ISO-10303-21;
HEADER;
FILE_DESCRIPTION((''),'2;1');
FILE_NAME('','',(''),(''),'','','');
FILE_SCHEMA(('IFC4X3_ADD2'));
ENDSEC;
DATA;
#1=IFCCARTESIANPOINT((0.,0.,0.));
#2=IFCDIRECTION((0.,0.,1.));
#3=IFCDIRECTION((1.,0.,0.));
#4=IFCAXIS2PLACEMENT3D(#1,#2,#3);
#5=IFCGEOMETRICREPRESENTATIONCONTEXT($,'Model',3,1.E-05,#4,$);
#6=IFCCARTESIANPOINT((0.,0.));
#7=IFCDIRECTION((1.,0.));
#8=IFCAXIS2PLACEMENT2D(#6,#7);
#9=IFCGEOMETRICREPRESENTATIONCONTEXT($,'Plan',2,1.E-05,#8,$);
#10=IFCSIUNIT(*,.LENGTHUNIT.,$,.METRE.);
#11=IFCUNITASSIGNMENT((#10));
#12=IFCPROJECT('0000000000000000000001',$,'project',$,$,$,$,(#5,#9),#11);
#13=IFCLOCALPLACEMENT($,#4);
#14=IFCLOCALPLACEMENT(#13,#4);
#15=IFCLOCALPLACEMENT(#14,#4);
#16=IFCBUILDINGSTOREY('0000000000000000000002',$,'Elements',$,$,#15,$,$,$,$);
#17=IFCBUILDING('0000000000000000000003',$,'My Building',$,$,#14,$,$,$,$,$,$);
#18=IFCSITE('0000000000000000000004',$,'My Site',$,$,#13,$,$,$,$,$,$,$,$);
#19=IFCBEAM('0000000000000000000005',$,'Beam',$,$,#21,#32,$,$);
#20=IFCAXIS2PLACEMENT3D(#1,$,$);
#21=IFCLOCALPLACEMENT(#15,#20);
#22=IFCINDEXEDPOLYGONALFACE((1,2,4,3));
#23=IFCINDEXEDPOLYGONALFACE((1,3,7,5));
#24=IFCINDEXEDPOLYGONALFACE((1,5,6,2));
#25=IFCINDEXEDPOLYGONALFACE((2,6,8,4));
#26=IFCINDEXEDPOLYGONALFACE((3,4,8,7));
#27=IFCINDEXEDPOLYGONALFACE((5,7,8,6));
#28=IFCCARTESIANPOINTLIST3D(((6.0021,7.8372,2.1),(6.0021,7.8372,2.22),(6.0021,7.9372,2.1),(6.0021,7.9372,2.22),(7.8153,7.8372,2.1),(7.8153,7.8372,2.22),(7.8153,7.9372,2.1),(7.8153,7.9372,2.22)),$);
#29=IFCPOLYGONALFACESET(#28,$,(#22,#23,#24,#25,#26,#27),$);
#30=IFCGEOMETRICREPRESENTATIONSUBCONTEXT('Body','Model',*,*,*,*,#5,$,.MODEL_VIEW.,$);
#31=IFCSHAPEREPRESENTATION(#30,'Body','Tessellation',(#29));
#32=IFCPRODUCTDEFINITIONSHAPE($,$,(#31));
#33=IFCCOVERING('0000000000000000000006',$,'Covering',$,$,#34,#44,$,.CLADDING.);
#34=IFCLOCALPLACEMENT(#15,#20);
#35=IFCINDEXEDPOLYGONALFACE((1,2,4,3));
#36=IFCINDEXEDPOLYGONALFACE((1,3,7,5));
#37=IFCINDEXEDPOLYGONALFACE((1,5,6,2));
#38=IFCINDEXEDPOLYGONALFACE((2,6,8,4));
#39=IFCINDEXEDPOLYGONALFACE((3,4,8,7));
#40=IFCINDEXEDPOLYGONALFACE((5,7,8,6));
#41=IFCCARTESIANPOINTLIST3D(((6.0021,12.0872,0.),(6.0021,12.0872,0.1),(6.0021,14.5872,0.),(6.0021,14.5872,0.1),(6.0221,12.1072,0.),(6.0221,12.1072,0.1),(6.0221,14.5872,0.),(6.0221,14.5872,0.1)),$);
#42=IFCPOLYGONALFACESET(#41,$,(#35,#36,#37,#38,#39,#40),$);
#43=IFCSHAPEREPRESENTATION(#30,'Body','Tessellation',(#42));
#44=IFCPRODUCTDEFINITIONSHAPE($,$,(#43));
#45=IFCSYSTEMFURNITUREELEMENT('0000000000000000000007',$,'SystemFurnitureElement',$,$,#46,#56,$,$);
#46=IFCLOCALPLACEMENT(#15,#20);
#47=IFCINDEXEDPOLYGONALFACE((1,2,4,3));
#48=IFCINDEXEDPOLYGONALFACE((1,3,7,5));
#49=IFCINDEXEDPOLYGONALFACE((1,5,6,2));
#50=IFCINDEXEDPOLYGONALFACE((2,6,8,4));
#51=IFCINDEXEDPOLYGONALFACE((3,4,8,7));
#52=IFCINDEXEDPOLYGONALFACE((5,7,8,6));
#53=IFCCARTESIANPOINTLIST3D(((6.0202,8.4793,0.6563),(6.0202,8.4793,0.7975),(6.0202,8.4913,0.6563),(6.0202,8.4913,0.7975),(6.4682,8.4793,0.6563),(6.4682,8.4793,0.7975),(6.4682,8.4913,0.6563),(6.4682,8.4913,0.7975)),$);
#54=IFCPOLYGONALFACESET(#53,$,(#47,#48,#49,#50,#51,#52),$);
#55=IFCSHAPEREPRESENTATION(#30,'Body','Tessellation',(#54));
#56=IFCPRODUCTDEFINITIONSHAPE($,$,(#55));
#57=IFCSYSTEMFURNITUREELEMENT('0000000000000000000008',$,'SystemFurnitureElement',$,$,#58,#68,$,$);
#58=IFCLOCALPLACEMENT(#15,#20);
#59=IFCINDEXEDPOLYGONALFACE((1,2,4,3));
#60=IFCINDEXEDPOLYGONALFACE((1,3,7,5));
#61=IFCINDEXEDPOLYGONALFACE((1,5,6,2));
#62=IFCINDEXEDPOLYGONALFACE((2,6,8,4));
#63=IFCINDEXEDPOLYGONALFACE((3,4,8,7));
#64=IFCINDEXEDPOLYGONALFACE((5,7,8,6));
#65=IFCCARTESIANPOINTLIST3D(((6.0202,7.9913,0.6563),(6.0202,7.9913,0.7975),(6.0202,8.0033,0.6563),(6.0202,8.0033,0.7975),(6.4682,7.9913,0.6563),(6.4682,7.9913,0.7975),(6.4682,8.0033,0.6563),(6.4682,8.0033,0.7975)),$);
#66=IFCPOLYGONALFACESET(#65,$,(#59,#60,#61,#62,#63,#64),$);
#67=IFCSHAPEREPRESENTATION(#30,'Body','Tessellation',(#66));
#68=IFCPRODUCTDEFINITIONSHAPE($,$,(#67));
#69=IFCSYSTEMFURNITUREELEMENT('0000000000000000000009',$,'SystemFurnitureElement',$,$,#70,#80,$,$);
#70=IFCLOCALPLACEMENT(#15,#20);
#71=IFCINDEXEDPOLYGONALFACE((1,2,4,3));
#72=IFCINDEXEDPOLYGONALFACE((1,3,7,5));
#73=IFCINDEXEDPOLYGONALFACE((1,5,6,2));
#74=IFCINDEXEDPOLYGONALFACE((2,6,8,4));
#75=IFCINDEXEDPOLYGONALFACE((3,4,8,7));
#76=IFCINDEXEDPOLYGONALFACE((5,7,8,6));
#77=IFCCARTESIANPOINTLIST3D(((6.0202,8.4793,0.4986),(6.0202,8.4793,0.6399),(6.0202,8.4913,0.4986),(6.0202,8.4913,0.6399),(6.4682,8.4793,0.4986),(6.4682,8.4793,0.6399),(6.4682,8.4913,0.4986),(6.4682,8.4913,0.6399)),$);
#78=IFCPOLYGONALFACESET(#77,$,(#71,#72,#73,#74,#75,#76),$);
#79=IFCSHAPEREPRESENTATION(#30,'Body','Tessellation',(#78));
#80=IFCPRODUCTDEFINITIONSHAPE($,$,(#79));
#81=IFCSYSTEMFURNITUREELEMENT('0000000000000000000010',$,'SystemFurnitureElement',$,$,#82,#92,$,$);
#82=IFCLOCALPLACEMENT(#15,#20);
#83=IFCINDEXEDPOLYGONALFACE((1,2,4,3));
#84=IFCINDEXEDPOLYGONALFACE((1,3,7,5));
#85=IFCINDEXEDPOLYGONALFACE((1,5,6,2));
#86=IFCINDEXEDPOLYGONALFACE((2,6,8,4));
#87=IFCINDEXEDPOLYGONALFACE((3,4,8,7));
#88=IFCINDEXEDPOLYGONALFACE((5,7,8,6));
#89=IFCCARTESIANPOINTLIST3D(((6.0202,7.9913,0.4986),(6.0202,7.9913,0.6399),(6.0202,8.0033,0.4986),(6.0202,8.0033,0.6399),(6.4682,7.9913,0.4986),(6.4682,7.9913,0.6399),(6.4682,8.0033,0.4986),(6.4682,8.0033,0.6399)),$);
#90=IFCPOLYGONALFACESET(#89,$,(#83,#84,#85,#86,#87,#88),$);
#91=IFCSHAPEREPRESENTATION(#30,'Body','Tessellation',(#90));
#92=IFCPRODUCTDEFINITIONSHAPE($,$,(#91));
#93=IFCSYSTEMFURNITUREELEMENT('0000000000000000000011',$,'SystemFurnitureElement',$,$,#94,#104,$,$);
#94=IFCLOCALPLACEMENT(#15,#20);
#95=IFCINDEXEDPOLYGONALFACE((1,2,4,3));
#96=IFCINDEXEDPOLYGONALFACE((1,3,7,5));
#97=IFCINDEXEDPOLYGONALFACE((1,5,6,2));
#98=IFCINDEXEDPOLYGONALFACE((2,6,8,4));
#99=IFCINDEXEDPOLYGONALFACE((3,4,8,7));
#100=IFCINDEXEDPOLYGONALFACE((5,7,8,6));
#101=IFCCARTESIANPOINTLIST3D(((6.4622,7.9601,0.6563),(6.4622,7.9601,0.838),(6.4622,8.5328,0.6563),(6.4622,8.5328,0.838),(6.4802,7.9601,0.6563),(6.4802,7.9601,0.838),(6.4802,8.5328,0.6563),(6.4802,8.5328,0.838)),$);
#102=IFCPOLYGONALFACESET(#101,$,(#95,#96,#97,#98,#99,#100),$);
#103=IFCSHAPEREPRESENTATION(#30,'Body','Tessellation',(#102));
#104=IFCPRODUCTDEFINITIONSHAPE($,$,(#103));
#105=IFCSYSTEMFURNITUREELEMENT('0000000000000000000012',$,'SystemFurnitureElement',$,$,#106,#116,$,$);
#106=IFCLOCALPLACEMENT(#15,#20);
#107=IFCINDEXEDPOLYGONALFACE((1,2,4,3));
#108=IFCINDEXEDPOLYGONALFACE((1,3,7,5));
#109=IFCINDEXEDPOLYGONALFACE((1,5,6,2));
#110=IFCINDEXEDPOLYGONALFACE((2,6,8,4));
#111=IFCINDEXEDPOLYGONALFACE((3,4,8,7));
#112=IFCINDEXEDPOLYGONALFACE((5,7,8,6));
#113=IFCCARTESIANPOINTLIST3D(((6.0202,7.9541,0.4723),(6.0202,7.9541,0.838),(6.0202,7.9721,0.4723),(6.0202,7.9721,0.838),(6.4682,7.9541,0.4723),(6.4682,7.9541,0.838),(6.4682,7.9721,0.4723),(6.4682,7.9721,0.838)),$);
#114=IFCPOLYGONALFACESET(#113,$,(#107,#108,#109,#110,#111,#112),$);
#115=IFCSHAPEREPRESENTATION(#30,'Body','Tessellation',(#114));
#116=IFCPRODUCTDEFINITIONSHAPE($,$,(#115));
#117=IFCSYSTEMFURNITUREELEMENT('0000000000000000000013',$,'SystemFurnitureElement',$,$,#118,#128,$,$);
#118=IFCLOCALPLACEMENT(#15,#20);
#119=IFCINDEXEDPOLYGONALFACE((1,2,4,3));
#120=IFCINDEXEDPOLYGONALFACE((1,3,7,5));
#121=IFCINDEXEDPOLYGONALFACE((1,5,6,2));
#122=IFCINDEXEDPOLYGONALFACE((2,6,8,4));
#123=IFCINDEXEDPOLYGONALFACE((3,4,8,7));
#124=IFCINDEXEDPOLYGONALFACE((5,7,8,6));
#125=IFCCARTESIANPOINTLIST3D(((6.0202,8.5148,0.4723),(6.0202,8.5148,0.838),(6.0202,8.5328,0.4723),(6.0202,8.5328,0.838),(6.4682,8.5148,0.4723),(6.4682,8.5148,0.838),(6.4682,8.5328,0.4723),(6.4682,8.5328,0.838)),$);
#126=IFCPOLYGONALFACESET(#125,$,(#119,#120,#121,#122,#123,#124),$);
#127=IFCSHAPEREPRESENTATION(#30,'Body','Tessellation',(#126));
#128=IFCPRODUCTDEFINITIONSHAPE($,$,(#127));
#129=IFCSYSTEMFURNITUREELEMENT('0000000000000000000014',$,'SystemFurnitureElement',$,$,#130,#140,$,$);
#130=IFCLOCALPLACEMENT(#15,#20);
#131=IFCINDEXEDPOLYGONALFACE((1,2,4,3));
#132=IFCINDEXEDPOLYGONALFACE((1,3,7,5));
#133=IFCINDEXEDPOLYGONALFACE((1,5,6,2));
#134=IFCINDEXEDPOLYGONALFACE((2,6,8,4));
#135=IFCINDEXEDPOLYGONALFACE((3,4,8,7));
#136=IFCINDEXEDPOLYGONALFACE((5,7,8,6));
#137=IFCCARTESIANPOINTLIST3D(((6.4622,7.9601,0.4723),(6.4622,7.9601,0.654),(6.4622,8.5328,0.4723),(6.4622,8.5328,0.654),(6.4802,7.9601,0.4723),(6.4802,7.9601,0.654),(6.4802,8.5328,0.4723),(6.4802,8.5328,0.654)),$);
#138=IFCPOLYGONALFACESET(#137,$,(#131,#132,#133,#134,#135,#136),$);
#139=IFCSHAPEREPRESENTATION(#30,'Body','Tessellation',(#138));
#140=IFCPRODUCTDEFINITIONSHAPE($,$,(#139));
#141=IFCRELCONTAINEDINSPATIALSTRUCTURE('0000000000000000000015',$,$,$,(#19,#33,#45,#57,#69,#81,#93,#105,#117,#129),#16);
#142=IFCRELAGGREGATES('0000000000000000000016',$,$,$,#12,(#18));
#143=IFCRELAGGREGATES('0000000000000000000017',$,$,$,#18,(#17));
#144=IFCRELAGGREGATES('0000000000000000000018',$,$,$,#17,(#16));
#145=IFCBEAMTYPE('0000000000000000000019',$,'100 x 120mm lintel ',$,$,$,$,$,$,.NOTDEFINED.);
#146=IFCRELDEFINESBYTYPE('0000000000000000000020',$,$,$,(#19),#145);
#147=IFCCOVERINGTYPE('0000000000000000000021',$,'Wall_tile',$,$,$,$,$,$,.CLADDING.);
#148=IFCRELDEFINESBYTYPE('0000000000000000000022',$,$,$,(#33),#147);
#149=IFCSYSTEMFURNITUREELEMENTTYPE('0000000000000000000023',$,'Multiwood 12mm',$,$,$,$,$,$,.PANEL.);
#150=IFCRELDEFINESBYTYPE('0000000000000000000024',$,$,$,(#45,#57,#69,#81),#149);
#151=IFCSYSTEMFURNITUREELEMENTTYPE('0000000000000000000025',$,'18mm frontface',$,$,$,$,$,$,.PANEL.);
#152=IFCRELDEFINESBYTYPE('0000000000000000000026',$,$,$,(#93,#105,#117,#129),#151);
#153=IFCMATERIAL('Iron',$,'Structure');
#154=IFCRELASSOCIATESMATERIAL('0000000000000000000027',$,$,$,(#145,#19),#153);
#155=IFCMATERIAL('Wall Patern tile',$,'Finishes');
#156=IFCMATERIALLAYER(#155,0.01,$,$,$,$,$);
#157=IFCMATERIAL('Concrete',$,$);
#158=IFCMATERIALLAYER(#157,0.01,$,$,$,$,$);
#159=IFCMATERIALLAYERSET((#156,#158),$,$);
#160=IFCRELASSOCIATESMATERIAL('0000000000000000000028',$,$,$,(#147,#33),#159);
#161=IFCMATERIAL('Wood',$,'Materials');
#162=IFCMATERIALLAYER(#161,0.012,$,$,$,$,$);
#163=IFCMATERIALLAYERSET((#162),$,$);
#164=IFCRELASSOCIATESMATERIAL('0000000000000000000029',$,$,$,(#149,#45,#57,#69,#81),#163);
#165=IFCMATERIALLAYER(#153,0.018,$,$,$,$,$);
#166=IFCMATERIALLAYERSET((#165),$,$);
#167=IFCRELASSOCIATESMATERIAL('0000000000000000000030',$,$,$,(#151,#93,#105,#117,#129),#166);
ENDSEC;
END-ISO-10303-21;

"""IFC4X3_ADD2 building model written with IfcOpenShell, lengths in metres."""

from ifc_helpers import new_model, si_unit, frame, origin_with_axes, origin_2d_with_axis, place, context, subcontext, project, spatial, line, indexed_curve, rectangle, outline, extrude, material, layer, layer_set, layer_usage, material_profile, profile_set, profile_usage, type_object, element, save


model = new_model("IFC4X3_ADD2")

# Units and contexts
model_context = context("Model", 3, precision=1e-05, world=origin_with_axes())
plan_context = context("Plan", 2, precision=1e-05, world=origin_2d_with_axis())
body_context = subcontext(model_context, "Body", "Model", "MODEL_VIEW")
ifc_project = project(units=[si_unit("LENGTHUNIT", "METRE")], contexts=[model_context, plan_context])

# Site, building, storey
site_placement = place(None, origin_with_axes())
site = spatial("IfcSite", under=ifc_project, at=site_placement, Name="My Site")
building_placement = place(site_placement, origin_with_axes())
building = spatial("IfcBuilding", under=site, at=building_placement, Name="My Building")
storey_placement = place(building_placement, origin_with_axes())
storey = spatial("IfcBuildingStorey", under=building, at=storey_placement, Name="Elements")

# Beam
ifc_material_1 = material(Name="Iron", Category="Structure")
ifc_material_profile = material_profile(ifc_material_1, rectangle(XDim=0.1, YDim=0.12))
ifc_profile_set = profile_set([ifc_material_profile], Name="blank")
ifc_profile_usage = profile_usage(ifc_profile_set, cardinal=5)
beam_type = type_object("IfcBeamType", Name="100 x 120mm lintel ", PredefinedType="NOTDEFINED", material=ifc_profile_set)
beam_placement = place(storey_placement, frame((6.0021, 7.8872, 2.16), z_axis=(1.0, 0.0, 0.0), x_axis=(0.0, 1.0, 0.0)))
element("IfcBeam", 1, at=beam_placement, inside=storey, type_object=beam_type, material=ifc_profile_usage, Name="Beam", context=body_context, shape_type="SweptSolid", body=[
    extrude(rectangle(XDim=0.1, YDim=0.12), origin_with_axes(), (0.0, 0.0, 1.0), 1.8132),
])

# Covering
ifc_material_2 = material(Name="Concrete")
ifc_material_3 = material(Name="Wall Patern tile", Category="Finishes")
ifc_layer_1 = layer(ifc_material_3, 0.01)
ifc_layer_2 = layer(ifc_material_2, 0.01)
ifc_layer_set_1 = layer_set([ifc_layer_1, ifc_layer_2])
ifc_layer_usage_1 = layer_usage(ifc_layer_set_1, "AXIS2", "POSITIVE", 0.0)
covering_type_1 = type_object("IfcCoveringType", Name="Wall_tile", PredefinedType="CLADDING", material=ifc_layer_set_1)
covering_1_placement = place(storey_placement, frame((6.0221, 12.0872, 0.0), z_axis=(0.0, 0.0, 1.0), x_axis=(0.0, 1.0, 0.0)))
element("IfcCovering", 2, at=covering_1_placement, inside=storey, type_object=covering_type_1, material=ifc_layer_usage_1, Name="Covering", PredefinedType="CLADDING", context=body_context, shape_type="SweptSolid", body=[
    extrude(outline(indexed_curve([(0.02, 0.0), (0.0, 0.02), (2.5, 0.02), (2.5, 0.0)], segments=[line(1, 2, 3, 4, 1)])), origin_with_axes(), (0.0, 0.0, 1.0), 0.1),
])

# System furniture elements
ifc_material_4 = material(Name="Wood", Category="Materials")
ifc_layer_3 = layer(ifc_material_4, 0.012)
ifc_layer_set_2 = layer_set([ifc_layer_3])
ifc_layer_usage_2 = layer_usage(ifc_layer_set_2, "AXIS2", "POSITIVE", 0.0)
system_furniture_element_type_1 = type_object("IfcSystemFurnitureElementType", Name="Multiwood 12mm", PredefinedType="PANEL", material=ifc_layer_set_2)
system_furniture_element_1_placement = place(storey_placement, frame((6.4682, 8.4913, 0.6563), z_axis=(0.0, 0.0, 1.0), x_axis=(-1.0, 0.000001, 0.0)))
element("IfcSystemFurnitureElement", 3, at=system_furniture_element_1_placement, inside=storey, type_object=system_furniture_element_type_1, material=ifc_layer_usage_2, Name="SystemFurnitureElement", context=body_context, shape_type="SweptSolid", body=[
    extrude(outline(indexed_curve([(0.0, 0.0), (0.0, 0.012), (0.448, 0.012), (0.448, 0.0)], segments=[line(1, 2, 3, 4, 1)])), origin_with_axes(), (0.0, 0.0, 1.0), 0.1413),
])
ifc_layer_usage_3 = layer_usage(ifc_layer_set_2, "AXIS2", "POSITIVE", 0.0)
system_furniture_element_2_placement = place(storey_placement, frame((6.4682, 8.0033, 0.6563), z_axis=(0.0, 0.0, 1.0), x_axis=(-1.0, 0.000001, 0.0)))
element("IfcSystemFurnitureElement", 4, at=system_furniture_element_2_placement, inside=storey, type_object=system_furniture_element_type_1, material=ifc_layer_usage_3, Name="SystemFurnitureElement", context=body_context, shape_type="SweptSolid", body=[
    extrude(outline(indexed_curve([(0.0, 0.0), (0.0, 0.012), (0.448, 0.012), (0.448, 0.0)], segments=[line(1, 2, 3, 4, 1)])), origin_with_axes(), (0.0, 0.0, 1.0), 0.1413),
])
ifc_layer_usage_4 = layer_usage(ifc_layer_set_2, "AXIS2", "POSITIVE", 0.0)
system_furniture_element_3_placement = place(storey_placement, frame((6.4682, 8.4913, 0.4986), z_axis=(0.0, 0.0, 1.0), x_axis=(-1.0, 0.000001, 0.0)))
element("IfcSystemFurnitureElement", 5, at=system_furniture_element_3_placement, inside=storey, type_object=system_furniture_element_type_1, material=ifc_layer_usage_4, Name="SystemFurnitureElement", context=body_context, shape_type="SweptSolid", body=[
    extrude(outline(indexed_curve([(0.0, 0.0), (0.0, 0.012), (0.448, 0.012), (0.448, 0.0)], segments=[line(1, 2, 3, 4, 1)])), origin_with_axes(), (0.0, 0.0, 1.0), 0.1413),
])
ifc_layer_usage_5 = layer_usage(ifc_layer_set_2, "AXIS2", "POSITIVE", 0.0)
system_furniture_element_4_placement = place(storey_placement, frame((6.4682, 8.0033, 0.4986), z_axis=(0.0, 0.0, 1.0), x_axis=(-1.0, 0.000001, 0.0)))
element("IfcSystemFurnitureElement", 6, at=system_furniture_element_4_placement, inside=storey, type_object=system_furniture_element_type_1, material=ifc_layer_usage_5, Name="SystemFurnitureElement", context=body_context, shape_type="SweptSolid", body=[
    extrude(outline(indexed_curve([(0.0, 0.0), (0.0, 0.012), (0.448, 0.012), (0.448, 0.0)], segments=[line(1, 2, 3, 4, 1)])), origin_with_axes(), (0.0, 0.0, 1.0), 0.1413),
])
ifc_layer_4 = layer(ifc_material_1, 0.018)
ifc_layer_set_3 = layer_set([ifc_layer_4])
ifc_layer_usage_6 = layer_usage(ifc_layer_set_3, "AXIS2", "POSITIVE", 0.0)
system_furniture_element_type_2 = type_object("IfcSystemFurnitureElementType", Name="18mm frontface", PredefinedType="PANEL", material=ifc_layer_set_3)
system_furniture_element_5_placement = place(storey_placement, frame((6.4802, 7.9601, 0.6563), z_axis=(0.0, 0.0, 1.0), x_axis=(0.000001, 1.0, 0.0)))
element("IfcSystemFurnitureElement", 7, at=system_furniture_element_5_placement, inside=storey, type_object=system_furniture_element_type_2, material=ifc_layer_usage_6, Name="SystemFurnitureElement", context=body_context, shape_type="SweptSolid", body=[
    extrude(outline(indexed_curve([(0.0, 0.0), (0.0, 0.018), (0.5727, 0.018), (0.5727, 0.0)], segments=[line(1, 2, 3, 4, 1)])), origin_with_axes(), (0.0, 0.0, 1.0), 0.1817),
])
ifc_layer_usage_7 = layer_usage(ifc_layer_set_3, "AXIS2", "POSITIVE", 0.0)
system_furniture_element_6_placement = place(storey_placement, frame((6.4682, 7.9721, 0.4723), z_axis=(0.0, 0.0, 1.0), x_axis=(-1.0, 0.000001, 0.0)))
element("IfcSystemFurnitureElement", 8, at=system_furniture_element_6_placement, inside=storey, type_object=system_furniture_element_type_2, material=ifc_layer_usage_7, Name="SystemFurnitureElement", context=body_context, shape_type="SweptSolid", body=[
    extrude(outline(indexed_curve([(0.0, 0.0), (0.0, 0.018), (0.448, 0.018), (0.448, 0.0)], segments=[line(1, 2, 3, 4, 1)])), origin_with_axes(), (0.0, 0.0, 1.0), 0.3657),
])
ifc_layer_usage_8 = layer_usage(ifc_layer_set_3, "AXIS2", "POSITIVE", 0.0)
system_furniture_element_7_placement = place(storey_placement, frame((6.4682, 8.5328, 0.4723), z_axis=(0.0, 0.0, 1.0), x_axis=(-1.0, 0.000001, 0.0)))
element("IfcSystemFurnitureElement", 9, at=system_furniture_element_7_placement, inside=storey, type_object=system_furniture_element_type_2, material=ifc_layer_usage_8, Name="SystemFurnitureElement", context=body_context, shape_type="SweptSolid", body=[
    extrude(outline(indexed_curve([(0.0, 0.0), (0.0, 0.018), (0.448, 0.018), (0.448, 0.0)], segments=[line(1, 2, 3, 4, 1)])), origin_with_axes(), (0.0, 0.0, 1.0), 0.3657),
])
ifc_layer_usage_9 = layer_usage(ifc_layer_set_3, "AXIS2", "POSITIVE", 0.0)
system_furniture_element_8_placement = place(storey_placement, frame((6.4802, 7.9601, 0.4723), z_axis=(0.0, 0.0, 1.0), x_axis=(0.000001, 1.0, 0.0)))
element("IfcSystemFurnitureElement", 10, at=system_furniture_element_8_placement, inside=storey, type_object=system_furniture_element_type_2, material=ifc_layer_usage_9, Name="SystemFurnitureElement", context=body_context, shape_type="SweptSolid", body=[
    extrude(outline(indexed_curve([(0.0, 0.0), (0.0, 0.018), (0.5727, 0.018), (0.5727, 0.0)], segments=[line(1, 2, 3, 4, 1)])), origin_with_axes(), (0.0, 0.0, 1.0), 0.1817),
])

save(model, "model.ifc")
